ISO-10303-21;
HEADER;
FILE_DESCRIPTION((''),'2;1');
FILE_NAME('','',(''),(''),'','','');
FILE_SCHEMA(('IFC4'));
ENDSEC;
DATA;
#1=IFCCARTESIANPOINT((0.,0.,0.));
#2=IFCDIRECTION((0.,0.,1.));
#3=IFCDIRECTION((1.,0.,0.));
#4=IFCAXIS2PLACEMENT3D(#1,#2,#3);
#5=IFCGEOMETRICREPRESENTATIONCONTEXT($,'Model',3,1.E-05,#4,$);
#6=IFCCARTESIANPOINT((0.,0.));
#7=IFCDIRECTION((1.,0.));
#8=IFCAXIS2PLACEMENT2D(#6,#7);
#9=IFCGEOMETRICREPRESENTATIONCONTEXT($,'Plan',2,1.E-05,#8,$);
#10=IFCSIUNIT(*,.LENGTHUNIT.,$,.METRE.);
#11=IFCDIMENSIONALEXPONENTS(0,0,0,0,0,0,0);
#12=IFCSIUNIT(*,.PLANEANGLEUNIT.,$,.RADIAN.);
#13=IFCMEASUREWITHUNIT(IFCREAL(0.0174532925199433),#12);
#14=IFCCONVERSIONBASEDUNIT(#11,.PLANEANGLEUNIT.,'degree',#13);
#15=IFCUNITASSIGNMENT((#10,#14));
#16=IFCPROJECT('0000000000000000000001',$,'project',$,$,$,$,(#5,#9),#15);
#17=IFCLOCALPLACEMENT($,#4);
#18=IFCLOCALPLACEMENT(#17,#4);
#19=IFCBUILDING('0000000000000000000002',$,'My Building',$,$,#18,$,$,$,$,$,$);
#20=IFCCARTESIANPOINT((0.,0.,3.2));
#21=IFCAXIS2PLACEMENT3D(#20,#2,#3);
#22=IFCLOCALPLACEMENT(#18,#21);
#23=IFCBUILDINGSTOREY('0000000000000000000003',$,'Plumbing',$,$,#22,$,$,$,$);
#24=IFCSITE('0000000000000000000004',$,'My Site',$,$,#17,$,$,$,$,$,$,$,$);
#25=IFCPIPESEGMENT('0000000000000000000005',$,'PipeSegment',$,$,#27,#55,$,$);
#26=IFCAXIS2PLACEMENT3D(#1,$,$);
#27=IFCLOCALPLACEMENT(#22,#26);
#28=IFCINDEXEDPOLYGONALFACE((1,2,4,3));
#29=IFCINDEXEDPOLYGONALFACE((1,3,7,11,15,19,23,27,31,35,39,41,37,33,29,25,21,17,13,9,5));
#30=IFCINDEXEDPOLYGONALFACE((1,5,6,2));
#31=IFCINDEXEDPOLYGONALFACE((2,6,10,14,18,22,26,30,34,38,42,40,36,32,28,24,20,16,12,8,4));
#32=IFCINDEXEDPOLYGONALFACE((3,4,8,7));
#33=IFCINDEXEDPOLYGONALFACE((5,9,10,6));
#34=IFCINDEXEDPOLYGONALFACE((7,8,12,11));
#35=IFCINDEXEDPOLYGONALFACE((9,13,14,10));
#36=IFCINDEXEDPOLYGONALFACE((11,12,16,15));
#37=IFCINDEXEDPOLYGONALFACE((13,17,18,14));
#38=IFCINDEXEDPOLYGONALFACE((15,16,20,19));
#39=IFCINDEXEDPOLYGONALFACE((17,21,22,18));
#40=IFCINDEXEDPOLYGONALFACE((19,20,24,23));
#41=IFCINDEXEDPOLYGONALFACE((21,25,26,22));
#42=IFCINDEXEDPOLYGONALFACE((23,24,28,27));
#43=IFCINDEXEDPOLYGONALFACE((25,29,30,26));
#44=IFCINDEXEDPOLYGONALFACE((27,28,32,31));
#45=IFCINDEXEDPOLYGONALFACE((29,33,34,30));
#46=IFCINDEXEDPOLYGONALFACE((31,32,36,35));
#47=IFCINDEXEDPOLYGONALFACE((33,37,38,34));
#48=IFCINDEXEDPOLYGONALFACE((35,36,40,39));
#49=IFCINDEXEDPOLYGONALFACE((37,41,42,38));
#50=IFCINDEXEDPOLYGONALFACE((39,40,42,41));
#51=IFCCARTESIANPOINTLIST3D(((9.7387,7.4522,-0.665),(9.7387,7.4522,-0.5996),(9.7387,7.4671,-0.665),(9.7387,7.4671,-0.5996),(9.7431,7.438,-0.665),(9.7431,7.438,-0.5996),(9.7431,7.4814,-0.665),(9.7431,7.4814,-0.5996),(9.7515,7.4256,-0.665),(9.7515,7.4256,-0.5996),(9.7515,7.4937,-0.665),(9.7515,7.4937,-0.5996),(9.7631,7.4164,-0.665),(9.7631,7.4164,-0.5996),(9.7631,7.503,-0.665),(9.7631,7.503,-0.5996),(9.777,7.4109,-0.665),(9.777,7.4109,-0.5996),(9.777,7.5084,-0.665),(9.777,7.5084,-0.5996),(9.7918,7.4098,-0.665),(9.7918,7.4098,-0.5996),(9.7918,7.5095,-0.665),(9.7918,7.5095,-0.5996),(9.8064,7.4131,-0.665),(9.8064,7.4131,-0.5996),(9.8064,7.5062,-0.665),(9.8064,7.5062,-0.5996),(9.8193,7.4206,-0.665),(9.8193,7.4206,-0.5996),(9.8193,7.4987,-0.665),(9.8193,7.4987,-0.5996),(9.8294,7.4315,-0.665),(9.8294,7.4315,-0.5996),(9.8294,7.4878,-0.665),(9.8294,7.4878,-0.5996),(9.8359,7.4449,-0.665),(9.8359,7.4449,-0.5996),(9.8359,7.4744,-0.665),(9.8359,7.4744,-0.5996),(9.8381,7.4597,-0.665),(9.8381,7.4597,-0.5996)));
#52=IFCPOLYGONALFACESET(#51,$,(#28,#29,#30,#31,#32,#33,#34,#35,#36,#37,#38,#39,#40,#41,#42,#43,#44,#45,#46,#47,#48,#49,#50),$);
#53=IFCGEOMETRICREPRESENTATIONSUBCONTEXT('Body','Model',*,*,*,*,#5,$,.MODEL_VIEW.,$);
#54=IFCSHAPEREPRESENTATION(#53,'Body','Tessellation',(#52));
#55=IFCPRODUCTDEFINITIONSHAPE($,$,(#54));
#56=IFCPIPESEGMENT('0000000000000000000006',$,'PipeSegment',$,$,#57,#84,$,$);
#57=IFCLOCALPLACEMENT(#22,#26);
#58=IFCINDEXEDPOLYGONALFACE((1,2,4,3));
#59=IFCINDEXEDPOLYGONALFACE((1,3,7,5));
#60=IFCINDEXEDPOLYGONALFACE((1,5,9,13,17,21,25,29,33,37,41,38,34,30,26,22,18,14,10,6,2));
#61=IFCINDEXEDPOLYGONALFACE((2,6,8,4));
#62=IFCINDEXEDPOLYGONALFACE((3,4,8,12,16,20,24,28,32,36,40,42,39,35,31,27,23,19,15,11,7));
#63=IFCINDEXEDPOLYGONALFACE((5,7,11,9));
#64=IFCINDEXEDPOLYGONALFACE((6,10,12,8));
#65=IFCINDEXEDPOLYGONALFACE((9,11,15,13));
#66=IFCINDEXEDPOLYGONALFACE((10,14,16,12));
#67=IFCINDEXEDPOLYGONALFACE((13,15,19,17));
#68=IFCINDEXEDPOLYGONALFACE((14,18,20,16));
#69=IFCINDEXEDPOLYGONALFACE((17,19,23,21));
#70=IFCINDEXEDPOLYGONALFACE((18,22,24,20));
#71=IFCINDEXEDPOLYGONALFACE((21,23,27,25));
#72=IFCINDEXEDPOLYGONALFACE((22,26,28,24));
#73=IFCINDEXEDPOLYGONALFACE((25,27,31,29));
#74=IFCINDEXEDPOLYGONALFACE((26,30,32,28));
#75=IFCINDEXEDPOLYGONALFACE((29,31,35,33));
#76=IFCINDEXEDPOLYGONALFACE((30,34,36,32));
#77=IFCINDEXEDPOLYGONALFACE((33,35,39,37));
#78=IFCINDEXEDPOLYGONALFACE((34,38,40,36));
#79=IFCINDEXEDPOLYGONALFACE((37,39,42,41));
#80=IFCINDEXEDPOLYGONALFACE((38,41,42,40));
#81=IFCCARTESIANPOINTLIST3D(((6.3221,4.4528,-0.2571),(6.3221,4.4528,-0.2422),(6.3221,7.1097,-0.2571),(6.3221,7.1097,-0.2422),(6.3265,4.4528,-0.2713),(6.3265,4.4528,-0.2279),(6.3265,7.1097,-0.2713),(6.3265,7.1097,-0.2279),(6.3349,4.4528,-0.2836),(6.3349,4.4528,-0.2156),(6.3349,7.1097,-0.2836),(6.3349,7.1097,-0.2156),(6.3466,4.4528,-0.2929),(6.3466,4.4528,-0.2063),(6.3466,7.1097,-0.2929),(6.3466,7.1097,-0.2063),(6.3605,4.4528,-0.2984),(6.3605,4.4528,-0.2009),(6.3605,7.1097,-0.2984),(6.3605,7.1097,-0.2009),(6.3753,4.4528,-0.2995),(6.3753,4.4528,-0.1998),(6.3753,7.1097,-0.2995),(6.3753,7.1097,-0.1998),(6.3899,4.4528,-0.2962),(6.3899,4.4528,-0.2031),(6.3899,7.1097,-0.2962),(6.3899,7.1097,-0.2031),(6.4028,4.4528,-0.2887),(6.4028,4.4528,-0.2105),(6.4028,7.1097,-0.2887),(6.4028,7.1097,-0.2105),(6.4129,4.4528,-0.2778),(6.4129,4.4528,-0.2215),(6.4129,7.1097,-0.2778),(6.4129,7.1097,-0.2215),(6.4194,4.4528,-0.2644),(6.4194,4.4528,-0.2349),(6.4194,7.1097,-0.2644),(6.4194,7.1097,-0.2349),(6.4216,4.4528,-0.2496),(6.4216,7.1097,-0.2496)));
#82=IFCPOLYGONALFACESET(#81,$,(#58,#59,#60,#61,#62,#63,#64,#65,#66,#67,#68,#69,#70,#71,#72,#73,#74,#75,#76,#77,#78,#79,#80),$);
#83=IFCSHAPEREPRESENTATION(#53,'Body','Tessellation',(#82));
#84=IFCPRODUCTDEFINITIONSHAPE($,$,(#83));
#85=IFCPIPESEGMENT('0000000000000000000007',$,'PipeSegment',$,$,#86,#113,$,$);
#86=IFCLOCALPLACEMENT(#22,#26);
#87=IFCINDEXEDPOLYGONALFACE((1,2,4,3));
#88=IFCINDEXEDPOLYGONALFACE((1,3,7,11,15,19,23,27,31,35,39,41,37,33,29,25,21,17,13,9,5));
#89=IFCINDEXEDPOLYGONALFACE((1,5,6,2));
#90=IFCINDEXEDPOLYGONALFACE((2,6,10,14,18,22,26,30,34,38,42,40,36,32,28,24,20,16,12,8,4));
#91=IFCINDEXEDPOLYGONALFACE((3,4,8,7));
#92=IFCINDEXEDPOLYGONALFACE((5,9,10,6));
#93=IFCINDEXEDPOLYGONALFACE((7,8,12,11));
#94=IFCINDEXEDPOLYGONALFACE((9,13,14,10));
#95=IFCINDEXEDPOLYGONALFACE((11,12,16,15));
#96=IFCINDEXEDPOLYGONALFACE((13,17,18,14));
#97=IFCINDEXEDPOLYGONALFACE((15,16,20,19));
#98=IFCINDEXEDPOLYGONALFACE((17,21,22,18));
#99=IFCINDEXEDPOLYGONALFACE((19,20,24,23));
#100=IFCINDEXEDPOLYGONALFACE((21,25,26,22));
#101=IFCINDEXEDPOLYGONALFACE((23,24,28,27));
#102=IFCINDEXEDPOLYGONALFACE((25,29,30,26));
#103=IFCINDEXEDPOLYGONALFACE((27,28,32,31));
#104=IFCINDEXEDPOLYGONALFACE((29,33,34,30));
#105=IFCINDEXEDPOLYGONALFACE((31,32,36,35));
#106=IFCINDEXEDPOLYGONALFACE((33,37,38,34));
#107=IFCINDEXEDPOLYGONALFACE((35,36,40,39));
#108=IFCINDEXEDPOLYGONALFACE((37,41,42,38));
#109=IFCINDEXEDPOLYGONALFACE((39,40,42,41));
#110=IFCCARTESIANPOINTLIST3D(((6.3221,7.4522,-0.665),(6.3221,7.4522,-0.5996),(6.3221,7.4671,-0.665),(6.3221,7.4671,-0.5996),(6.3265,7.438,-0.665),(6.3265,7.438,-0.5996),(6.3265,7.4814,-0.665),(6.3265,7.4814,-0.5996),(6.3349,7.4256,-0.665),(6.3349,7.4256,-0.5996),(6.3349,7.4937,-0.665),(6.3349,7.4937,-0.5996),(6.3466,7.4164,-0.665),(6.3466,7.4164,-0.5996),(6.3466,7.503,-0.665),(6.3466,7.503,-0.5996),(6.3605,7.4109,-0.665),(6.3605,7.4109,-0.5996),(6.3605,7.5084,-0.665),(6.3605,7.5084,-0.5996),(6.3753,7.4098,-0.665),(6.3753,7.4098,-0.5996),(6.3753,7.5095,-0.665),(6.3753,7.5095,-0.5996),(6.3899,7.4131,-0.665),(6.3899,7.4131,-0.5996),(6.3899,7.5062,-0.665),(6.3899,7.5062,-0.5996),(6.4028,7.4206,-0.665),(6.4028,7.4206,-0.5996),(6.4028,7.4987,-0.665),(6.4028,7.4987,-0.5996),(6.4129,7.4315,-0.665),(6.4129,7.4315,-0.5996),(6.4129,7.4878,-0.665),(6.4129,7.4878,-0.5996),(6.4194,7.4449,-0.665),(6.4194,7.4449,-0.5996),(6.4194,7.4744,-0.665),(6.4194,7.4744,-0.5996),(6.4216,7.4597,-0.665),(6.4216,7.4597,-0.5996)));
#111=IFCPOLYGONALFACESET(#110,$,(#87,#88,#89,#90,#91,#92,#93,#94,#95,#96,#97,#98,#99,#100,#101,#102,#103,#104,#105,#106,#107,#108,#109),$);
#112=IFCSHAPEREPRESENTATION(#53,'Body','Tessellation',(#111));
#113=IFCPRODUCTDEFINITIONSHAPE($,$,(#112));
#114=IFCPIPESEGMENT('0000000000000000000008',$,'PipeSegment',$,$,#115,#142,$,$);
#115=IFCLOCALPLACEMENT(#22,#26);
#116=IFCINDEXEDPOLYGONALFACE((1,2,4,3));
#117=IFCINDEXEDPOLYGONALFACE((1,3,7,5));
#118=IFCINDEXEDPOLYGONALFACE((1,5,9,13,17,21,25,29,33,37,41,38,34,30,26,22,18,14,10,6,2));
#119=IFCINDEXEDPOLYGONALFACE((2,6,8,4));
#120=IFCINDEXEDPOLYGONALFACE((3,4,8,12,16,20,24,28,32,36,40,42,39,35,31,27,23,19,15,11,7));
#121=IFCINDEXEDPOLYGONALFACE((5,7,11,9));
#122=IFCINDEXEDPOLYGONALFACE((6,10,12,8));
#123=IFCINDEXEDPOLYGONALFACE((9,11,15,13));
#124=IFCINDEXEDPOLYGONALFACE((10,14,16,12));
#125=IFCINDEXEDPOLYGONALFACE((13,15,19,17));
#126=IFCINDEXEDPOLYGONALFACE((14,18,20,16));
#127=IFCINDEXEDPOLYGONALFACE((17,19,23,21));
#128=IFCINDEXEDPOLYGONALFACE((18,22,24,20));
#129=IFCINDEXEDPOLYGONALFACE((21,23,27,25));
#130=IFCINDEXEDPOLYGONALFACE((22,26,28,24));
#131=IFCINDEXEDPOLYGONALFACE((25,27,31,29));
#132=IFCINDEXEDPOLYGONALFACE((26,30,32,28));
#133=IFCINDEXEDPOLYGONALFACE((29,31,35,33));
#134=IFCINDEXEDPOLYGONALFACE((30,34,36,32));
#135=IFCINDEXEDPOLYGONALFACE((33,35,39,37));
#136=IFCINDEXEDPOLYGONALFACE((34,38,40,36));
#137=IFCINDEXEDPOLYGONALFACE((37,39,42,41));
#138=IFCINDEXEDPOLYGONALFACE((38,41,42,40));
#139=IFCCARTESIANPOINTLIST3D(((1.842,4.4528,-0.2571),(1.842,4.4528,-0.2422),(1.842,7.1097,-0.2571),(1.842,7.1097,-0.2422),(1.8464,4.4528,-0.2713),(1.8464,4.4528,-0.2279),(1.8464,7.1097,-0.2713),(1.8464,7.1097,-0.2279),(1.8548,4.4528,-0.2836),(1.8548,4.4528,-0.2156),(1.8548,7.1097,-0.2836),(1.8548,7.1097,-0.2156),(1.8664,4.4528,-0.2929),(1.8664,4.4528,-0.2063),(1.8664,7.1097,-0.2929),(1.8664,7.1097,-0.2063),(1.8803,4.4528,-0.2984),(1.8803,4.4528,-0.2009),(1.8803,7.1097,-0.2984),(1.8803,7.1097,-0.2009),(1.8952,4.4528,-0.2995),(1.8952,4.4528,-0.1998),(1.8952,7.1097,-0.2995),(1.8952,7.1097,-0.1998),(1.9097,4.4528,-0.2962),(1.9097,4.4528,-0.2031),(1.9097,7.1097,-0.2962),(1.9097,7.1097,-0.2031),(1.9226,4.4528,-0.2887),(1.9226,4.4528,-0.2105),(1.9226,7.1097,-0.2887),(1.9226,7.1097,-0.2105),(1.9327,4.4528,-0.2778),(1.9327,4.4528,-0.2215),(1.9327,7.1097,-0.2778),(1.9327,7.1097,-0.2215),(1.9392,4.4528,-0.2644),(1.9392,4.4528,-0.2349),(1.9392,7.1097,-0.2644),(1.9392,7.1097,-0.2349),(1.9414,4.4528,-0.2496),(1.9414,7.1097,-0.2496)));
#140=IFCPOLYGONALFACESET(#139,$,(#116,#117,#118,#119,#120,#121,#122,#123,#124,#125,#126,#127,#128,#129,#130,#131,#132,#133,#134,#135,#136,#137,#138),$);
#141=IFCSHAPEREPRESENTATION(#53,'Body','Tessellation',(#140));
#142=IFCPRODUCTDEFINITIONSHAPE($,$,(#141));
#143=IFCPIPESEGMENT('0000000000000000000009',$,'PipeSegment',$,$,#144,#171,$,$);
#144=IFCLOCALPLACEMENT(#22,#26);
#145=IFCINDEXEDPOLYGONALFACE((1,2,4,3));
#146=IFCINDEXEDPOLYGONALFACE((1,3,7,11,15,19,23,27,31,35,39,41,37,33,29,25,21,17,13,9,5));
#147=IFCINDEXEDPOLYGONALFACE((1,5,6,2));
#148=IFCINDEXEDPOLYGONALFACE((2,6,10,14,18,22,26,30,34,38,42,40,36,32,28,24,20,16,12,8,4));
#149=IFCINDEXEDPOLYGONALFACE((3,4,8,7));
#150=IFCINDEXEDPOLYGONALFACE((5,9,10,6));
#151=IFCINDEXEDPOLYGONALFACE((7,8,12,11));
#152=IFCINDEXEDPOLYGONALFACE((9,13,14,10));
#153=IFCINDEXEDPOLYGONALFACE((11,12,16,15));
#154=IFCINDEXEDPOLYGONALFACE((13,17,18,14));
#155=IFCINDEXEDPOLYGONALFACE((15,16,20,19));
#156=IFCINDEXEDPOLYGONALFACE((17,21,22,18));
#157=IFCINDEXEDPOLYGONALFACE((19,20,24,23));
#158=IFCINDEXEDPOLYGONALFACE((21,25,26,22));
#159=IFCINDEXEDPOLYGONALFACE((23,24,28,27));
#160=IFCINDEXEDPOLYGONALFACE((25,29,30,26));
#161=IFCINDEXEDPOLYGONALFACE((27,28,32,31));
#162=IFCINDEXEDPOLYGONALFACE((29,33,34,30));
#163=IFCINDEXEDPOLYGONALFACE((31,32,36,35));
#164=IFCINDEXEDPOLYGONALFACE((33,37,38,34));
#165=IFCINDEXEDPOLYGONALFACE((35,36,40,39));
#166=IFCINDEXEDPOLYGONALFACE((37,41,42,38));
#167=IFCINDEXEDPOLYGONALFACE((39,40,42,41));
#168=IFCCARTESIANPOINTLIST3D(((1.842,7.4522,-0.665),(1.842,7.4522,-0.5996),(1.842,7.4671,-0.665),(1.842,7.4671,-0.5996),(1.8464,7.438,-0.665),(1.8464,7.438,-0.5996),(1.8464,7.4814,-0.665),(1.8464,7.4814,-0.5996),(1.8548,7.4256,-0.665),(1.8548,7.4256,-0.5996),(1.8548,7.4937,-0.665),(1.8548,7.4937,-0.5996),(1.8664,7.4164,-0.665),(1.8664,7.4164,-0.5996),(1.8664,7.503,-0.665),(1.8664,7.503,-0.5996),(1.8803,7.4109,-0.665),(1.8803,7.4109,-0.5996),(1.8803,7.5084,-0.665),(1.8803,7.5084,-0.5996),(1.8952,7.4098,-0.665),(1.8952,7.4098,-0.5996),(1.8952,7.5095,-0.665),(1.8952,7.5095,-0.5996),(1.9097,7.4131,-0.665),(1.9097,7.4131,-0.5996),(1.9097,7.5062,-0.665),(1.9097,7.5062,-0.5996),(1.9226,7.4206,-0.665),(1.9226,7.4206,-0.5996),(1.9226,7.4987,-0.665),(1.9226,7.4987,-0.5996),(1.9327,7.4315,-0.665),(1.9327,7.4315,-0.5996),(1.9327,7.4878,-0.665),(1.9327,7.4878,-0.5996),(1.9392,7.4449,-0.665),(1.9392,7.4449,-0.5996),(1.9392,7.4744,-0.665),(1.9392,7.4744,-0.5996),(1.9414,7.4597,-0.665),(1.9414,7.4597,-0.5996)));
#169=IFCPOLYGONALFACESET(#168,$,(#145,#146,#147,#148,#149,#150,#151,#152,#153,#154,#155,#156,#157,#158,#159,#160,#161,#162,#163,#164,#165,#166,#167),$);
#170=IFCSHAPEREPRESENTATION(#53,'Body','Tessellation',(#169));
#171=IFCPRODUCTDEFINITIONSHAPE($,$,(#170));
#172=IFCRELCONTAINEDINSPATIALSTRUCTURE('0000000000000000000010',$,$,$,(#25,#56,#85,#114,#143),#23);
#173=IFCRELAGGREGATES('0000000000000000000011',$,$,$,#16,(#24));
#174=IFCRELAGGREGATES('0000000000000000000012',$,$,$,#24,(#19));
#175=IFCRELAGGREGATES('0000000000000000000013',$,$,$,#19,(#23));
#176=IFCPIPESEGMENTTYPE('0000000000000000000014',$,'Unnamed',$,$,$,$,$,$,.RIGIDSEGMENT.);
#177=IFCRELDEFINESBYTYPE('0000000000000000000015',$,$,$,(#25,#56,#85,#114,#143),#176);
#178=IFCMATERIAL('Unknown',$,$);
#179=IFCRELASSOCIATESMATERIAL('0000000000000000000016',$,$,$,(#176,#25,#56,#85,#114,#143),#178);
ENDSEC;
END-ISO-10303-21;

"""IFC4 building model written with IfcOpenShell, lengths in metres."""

from ifc_helpers import new_model, entity, si_unit, converted_unit, frame, origin_with_axes, origin_2d_with_axis, place, context, subcontext, project, spatial, circle, extrude, material, material_profile, profile_set, profile_usage, type_object, element, save


model = new_model("IFC4")

# Units and contexts
model_context = context("Model", 3, precision=1e-05, world=origin_with_axes())
plan_context = context("Plan", 2, precision=1e-05, world=origin_2d_with_axis())
body_context = subcontext(model_context, "Body", "Model", "MODEL_VIEW")
ifc_project = project(units=[si_unit("LENGTHUNIT", "METRE"), converted_unit("PLANEANGLEUNIT", "degree", entity("IfcReal", 0.0174532925199433), si_unit("PLANEANGLEUNIT", "RADIAN"), dimensions=[0, 0, 0, 0, 0, 0, 0])], contexts=[model_context, plan_context])

# Site, building, storey
site_placement = place(None, origin_with_axes())
site = spatial("IfcSite", under=ifc_project, at=site_placement, Name="My Site")
building_placement = place(site_placement, origin_with_axes())
building = spatial("IfcBuilding", under=site, at=building_placement, Name="My Building")
storey_placement = place(building_placement, frame((0.0, 0.0, 3.2), z_axis=(0.0, 0.0, 1.0), x_axis=(1.0, 0.0, 0.0)))
storey = spatial("IfcBuildingStorey", under=building, at=storey_placement, Name="Plumbing")

# Pipe segments
ifc_material = material(Name="Unknown")
ifc_material_profile = material_profile(ifc_material, circle(Radius=0.05))
ifc_profile_set = profile_set([ifc_material_profile])
pipe_segment_type = type_object("IfcPipeSegmentType", Name="Unnamed", PredefinedType="RIGIDSEGMENT", material=ifc_profile_set)
ifc_profile_usage_1 = profile_usage(ifc_profile_set, cardinal=5)
pipe_segment_1_placement = place(storey_placement, frame((9.7881, 7.4597, -0.5996), z_axis=(0.0, 0.0, -1.0), x_axis=(1.0, 0.0, 0.0)))
element("IfcPipeSegment", 1, at=pipe_segment_1_placement, inside=storey, type_object=pipe_segment_type, material=ifc_profile_usage_1, Name="PipeSegment", context=body_context, shape_type="SweptSolid", body=[
    extrude(circle(Radius=0.05), origin_with_axes(), (0.0, 0.0, 1.0), 0.0654),
])
ifc_profile_usage_2 = profile_usage(ifc_profile_set, cardinal=5)
pipe_segment_2_placement = place(storey_placement, frame((6.3716, 7.1097, -0.2496), z_axis=(0.0, -1.0, 0.0), x_axis=(1.0, 0.0, 0.0)))
element("IfcPipeSegment", 2, at=pipe_segment_2_placement, inside=storey, type_object=pipe_segment_type, material=ifc_profile_usage_2, Name="PipeSegment", context=body_context, shape_type="SweptSolid", body=[
    extrude(circle(Radius=0.05), origin_with_axes(), (0.0, 0.0, 1.0), 2.6568),
])
ifc_profile_usage_3 = profile_usage(ifc_profile_set, cardinal=5)
pipe_segment_3_placement = place(storey_placement, frame((6.3716, 7.4597, -0.5996), z_axis=(0.0, 0.0, -1.0), x_axis=(1.0, 0.0, 0.0)))
element("IfcPipeSegment", 3, at=pipe_segment_3_placement, inside=storey, type_object=pipe_segment_type, material=ifc_profile_usage_3, Name="PipeSegment", context=body_context, shape_type="SweptSolid", body=[
    extrude(circle(Radius=0.05), origin_with_axes(), (0.0, 0.0, 1.0), 0.0654),
])
ifc_profile_usage_4 = profile_usage(ifc_profile_set, cardinal=5)
pipe_segment_4_placement = place(storey_placement, frame((1.8914, 7.1097, -0.2496), z_axis=(0.0, -1.0, 0.0), x_axis=(1.0, 0.0, 0.0)))
element("IfcPipeSegment", 4, at=pipe_segment_4_placement, inside=storey, type_object=pipe_segment_type, material=ifc_profile_usage_4, Name="PipeSegment", context=body_context, shape_type="SweptSolid", body=[
    extrude(circle(Radius=0.05), origin_with_axes(), (0.0, 0.0, 1.0), 2.6568),
])
ifc_profile_usage_5 = profile_usage(ifc_profile_set, cardinal=5)
pipe_segment_5_placement = place(storey_placement, frame((1.8914, 7.4597, -0.5996), z_axis=(0.0, 0.0, -1.0), x_axis=(1.0, 0.0, 0.0)))
element("IfcPipeSegment", 5, at=pipe_segment_5_placement, inside=storey, type_object=pipe_segment_type, material=ifc_profile_usage_5, Name="PipeSegment", context=body_context, shape_type="SweptSolid", body=[
    extrude(circle(Radius=0.05), origin_with_axes(), (0.0, 0.0, 1.0), 0.0654),
])

save(model, "model.ifc")
